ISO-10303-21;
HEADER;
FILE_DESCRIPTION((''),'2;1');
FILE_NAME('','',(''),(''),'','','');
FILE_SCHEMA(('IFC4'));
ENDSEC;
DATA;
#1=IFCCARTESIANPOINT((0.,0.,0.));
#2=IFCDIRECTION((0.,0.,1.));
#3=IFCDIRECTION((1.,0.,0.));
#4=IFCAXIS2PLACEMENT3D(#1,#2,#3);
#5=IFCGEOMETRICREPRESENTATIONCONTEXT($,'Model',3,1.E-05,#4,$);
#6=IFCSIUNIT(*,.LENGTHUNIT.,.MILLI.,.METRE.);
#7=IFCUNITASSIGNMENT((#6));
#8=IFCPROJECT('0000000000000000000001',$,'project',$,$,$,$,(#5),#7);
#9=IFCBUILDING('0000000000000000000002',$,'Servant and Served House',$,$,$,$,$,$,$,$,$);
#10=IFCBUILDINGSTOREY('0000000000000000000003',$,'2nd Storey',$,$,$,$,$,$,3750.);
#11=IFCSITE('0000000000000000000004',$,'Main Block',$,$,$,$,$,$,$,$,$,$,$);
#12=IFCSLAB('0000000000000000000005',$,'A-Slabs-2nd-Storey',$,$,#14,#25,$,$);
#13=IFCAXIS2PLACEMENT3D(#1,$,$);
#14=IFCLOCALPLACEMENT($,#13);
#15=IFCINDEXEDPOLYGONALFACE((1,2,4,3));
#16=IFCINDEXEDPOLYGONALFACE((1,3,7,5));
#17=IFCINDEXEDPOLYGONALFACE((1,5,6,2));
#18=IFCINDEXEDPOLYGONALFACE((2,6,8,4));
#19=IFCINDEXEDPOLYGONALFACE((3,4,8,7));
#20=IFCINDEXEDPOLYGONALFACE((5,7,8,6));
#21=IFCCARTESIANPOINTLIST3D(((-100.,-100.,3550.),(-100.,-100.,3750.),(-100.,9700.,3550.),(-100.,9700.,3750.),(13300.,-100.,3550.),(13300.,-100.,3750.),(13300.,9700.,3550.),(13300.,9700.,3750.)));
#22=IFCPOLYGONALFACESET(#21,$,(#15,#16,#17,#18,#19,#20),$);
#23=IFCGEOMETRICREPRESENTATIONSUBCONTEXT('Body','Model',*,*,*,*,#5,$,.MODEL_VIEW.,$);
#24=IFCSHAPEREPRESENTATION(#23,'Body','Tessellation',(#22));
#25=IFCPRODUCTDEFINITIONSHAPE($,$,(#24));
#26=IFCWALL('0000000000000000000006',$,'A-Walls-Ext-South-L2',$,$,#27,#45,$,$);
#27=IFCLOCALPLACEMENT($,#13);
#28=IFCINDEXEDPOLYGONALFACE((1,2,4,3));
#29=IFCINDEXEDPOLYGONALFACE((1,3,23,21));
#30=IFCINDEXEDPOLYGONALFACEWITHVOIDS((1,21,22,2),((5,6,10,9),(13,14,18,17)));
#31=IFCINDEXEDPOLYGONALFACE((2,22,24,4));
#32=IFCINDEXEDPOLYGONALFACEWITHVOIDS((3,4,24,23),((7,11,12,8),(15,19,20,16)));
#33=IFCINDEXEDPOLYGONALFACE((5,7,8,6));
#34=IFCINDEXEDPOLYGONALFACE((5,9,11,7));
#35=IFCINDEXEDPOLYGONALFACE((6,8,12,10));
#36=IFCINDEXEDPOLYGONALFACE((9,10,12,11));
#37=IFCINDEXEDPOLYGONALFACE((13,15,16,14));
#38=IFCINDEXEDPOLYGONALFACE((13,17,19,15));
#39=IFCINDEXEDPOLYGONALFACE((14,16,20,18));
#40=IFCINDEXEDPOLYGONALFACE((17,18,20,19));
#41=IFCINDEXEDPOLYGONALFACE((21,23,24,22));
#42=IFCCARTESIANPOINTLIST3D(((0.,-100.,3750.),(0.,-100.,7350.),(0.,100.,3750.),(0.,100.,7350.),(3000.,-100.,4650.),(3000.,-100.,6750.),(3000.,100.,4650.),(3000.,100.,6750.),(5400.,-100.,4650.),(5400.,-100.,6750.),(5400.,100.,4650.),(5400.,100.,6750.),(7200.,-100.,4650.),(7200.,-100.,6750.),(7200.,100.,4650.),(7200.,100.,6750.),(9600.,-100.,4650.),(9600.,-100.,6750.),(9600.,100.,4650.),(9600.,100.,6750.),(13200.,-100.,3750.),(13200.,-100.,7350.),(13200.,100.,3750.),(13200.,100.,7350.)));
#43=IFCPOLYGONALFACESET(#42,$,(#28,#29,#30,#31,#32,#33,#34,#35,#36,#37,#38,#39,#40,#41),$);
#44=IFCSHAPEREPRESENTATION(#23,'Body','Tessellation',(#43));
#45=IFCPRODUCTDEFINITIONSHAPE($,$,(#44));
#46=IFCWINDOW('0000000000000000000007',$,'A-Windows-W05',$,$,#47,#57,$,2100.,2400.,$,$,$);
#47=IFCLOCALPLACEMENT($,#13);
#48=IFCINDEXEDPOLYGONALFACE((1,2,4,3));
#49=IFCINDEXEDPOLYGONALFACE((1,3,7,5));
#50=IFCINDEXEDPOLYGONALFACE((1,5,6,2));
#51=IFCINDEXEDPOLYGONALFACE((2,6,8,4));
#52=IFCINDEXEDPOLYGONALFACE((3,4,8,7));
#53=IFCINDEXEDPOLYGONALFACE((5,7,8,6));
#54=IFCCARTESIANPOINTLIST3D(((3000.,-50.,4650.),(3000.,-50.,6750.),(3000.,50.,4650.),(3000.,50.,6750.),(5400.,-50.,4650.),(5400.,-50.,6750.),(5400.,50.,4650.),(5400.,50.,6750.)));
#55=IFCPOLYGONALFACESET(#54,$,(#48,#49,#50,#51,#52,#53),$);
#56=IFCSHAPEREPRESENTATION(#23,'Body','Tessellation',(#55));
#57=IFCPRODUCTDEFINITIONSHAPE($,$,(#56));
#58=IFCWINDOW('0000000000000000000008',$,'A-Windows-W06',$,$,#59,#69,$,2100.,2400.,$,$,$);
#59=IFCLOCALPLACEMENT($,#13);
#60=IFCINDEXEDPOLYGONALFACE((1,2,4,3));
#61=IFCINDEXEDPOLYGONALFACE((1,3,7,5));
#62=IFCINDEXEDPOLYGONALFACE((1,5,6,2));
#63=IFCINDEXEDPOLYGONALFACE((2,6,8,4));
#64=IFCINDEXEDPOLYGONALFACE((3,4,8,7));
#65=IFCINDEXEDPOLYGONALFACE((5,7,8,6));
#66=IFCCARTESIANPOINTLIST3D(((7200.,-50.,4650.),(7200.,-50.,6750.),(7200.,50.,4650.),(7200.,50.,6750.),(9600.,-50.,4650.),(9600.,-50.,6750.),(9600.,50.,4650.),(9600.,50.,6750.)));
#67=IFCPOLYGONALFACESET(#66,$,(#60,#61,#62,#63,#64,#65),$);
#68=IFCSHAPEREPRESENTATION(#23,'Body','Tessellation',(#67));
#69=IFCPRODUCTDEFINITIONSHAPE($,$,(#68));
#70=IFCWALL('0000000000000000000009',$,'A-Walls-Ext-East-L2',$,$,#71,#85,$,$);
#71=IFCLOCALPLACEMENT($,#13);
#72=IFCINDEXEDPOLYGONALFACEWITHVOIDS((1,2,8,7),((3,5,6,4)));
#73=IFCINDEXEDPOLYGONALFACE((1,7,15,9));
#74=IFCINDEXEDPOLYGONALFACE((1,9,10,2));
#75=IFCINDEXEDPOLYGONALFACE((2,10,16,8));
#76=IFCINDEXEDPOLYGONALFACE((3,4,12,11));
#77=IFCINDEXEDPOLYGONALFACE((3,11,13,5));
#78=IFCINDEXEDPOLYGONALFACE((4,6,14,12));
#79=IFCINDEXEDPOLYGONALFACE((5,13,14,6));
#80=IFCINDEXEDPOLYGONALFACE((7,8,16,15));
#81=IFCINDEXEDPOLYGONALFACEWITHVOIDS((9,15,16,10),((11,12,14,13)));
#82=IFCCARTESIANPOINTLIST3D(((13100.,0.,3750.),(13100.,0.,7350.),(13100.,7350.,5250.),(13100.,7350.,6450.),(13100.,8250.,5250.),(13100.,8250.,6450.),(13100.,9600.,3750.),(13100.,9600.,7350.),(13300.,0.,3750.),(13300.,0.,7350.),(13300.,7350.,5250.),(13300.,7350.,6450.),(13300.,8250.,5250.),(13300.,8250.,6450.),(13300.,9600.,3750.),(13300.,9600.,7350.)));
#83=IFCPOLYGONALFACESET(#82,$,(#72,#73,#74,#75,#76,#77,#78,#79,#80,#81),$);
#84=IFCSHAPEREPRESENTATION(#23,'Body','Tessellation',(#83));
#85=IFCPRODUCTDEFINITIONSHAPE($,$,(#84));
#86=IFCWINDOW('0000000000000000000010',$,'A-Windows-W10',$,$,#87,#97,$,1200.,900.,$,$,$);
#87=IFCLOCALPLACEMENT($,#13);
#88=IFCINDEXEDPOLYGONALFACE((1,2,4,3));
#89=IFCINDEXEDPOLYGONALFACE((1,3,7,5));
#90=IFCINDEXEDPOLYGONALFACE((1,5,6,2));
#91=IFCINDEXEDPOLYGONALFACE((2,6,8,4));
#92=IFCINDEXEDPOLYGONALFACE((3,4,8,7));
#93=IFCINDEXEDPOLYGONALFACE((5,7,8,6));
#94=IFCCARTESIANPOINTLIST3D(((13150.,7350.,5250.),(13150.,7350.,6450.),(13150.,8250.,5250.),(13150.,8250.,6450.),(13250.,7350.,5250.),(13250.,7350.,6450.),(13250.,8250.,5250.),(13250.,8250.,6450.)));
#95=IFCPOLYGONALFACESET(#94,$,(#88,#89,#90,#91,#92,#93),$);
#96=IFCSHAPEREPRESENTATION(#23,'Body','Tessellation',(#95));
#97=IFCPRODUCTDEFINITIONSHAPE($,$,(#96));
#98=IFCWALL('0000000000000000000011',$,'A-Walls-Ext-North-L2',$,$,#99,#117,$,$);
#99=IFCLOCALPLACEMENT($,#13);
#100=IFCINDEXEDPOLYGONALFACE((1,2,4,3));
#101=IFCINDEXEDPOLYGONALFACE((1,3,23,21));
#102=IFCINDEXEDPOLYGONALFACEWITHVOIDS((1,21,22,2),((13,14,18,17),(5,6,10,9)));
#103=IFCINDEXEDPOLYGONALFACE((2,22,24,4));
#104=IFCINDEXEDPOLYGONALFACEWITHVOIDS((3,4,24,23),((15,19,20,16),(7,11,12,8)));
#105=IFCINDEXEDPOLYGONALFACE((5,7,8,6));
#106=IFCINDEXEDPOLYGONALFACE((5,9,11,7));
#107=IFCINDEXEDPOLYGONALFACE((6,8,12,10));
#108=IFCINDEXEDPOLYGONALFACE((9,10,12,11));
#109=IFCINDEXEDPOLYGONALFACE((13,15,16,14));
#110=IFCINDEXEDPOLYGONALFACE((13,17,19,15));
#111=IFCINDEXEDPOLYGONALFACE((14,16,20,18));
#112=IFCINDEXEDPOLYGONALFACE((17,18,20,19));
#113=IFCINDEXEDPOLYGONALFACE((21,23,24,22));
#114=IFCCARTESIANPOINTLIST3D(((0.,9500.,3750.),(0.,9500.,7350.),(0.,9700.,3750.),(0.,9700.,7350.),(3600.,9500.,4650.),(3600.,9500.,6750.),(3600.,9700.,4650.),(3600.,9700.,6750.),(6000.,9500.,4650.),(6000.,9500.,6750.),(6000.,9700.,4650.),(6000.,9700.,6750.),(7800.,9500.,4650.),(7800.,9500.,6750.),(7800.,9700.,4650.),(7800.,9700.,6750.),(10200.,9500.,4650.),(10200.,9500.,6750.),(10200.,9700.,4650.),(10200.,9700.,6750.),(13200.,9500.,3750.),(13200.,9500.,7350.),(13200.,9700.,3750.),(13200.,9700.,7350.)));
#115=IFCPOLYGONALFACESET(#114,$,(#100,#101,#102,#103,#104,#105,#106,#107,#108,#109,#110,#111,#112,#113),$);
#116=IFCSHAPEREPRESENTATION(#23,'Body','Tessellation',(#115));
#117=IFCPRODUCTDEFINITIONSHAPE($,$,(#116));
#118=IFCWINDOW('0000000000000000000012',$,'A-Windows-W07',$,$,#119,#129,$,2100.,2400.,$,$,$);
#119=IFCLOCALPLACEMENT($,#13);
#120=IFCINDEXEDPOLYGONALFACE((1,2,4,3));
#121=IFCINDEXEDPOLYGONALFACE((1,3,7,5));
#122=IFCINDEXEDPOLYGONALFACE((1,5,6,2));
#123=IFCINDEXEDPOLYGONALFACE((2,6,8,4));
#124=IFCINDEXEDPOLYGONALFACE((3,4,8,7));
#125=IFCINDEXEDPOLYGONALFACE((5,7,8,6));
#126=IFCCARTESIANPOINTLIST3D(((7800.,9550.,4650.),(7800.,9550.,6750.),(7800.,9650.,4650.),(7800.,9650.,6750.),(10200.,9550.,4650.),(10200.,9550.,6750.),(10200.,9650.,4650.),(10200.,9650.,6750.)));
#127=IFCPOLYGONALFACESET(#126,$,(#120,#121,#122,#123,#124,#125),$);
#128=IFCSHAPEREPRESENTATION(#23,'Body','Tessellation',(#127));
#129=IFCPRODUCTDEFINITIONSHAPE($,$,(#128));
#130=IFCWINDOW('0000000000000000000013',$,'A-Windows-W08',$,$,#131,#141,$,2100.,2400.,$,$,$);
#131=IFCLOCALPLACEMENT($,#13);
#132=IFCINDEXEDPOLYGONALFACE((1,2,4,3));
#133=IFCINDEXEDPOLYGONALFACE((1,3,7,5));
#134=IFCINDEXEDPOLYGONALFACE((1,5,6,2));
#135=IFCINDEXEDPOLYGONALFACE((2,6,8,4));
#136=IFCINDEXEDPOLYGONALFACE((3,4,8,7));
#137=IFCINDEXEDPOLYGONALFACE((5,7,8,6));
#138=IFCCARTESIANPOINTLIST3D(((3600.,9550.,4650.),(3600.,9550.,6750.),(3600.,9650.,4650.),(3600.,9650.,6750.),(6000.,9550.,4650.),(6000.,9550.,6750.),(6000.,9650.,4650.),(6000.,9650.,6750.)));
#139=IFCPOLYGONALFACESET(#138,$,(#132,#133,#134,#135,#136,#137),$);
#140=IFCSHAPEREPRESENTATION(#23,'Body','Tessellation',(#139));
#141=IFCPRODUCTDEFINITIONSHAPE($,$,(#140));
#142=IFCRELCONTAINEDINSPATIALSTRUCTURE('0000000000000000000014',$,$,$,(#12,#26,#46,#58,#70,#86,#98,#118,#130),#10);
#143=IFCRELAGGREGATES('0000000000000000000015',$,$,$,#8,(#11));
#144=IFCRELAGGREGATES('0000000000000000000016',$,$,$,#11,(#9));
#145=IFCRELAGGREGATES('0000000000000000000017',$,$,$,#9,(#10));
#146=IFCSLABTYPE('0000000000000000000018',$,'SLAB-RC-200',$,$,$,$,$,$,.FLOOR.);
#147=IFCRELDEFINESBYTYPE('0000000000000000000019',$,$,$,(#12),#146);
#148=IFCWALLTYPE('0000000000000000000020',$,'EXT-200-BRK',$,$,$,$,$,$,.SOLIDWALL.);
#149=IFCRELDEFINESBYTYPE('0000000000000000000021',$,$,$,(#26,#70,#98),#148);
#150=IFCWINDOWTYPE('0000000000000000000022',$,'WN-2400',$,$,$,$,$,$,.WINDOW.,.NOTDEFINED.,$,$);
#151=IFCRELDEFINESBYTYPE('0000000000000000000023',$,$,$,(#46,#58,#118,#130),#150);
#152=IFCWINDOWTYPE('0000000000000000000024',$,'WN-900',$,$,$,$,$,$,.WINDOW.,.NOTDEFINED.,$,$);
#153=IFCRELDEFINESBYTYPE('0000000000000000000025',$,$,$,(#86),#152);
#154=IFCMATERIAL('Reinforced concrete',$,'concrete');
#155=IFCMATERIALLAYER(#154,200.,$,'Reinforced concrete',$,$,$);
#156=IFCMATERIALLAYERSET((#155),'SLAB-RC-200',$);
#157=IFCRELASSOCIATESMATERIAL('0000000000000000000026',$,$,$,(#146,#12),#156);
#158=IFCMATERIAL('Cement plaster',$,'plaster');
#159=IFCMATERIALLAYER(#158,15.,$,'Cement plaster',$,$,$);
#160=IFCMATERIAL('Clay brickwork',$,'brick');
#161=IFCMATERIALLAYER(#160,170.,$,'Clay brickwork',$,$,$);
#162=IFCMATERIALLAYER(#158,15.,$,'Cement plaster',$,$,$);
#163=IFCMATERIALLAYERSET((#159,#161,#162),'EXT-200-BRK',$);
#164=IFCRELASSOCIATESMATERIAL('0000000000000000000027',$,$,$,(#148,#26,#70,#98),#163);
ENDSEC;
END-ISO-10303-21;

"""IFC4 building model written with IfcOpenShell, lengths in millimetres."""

from ifc_helpers import new_model, si_unit, frame, origin_with_axes, place, context, subcontext, project, spatial, indexed_curve, outline, extrude, material, layer, layer_set, layer_usage, type_object, element, fill, save


model = new_model("IFC4")

# Units and contexts
model_context = context("Model", 3, precision=1e-05, world=origin_with_axes())
body_context = subcontext(model_context, "Body", "Model", "MODEL_VIEW")
ifc_project = project(units=[si_unit("LENGTHUNIT", "METRE", prefix="MILLI")], contexts=[model_context])

# Site, building, storey
site = spatial("IfcSite", under=ifc_project, Name="Main Block")
building = spatial("IfcBuilding", under=site, Name="Servant and Served House")
storey = spatial("IfcBuildingStorey", under=building, Name="2nd Storey", Elevation=3750.0)

# Slab
ifc_material_1 = material(Name="Reinforced concrete", Category="concrete")
ifc_layer_1 = layer(ifc_material_1, 200.0, Name="Reinforced concrete")
ifc_layer_set_1 = layer_set([ifc_layer_1], Name="SLAB-RC-200")
ifc_layer_usage_1 = layer_usage(ifc_layer_set_1, "AXIS3", "POSITIVE", 0.0)
slab_type = type_object("IfcSlabType", Name="SLAB-RC-200", PredefinedType="FLOOR", material=ifc_layer_set_1)
slab_placement = place(None, frame((0.0, 0.0, 3550.0), z_axis=(0.0, 0.0, 1.0), x_axis=(1.0, 0.0, 0.0)))
element("IfcSlab", 1, at=slab_placement, inside=storey, type_object=slab_type, material=ifc_layer_usage_1, Name="A-Slabs-2nd-Storey", context=body_context, shape_type="SweptSolid", body=[
    extrude(outline(indexed_curve([(-100.0, -100.0), (13300.0, -100.0), (13300.0, 9700.0), (-100.0, 9700.0)])), None, (0.0, 0.0, 1.0), 200.0),
])

# Wall, openings, windows
ifc_material_2 = material(Name="Cement plaster", Category="plaster")
ifc_layer_2 = layer(ifc_material_2, 15.0, Name="Cement plaster")
ifc_material_3 = material(Name="Clay brickwork", Category="brick")
ifc_layer_3 = layer(ifc_material_3, 170.0, Name="Clay brickwork")
ifc_layer_4 = layer(ifc_material_2, 15.0, Name="Cement plaster")
ifc_layer_set_2 = layer_set([ifc_layer_2, ifc_layer_3, ifc_layer_4], Name="EXT-200-BRK")
ifc_layer_usage_2 = layer_usage(ifc_layer_set_2, "AXIS2", "POSITIVE", 0.0)
wall_type_1 = type_object("IfcWallType", Name="EXT-200-BRK", PredefinedType="SOLIDWALL", material=ifc_layer_set_2)
wall_1_placement = place(None, frame((0.0, -100.0, 3750.0), z_axis=(0.0, 0.0, 1.0), x_axis=(1.0, 0.0, 0.0)))
wall_1 = element("IfcWall", 2, at=wall_1_placement, inside=storey, type_object=wall_type_1, material=ifc_layer_usage_2, Name="A-Walls-Ext-South-L2", context=body_context, shape_type="SweptSolid", body=[
    extrude(outline(indexed_curve([(0.0, 0.0), (0.0, 200.0), (13200.0, 200.0), (13200.0, 0.0), (0.0, 0.0)], self_intersect=False)), origin_with_axes(), (0.0, 0.0, 1.0), 3600.0),
])
opening_1_placement = place(wall_1_placement, frame((4200.0, 100.0, 900.0), z_axis=(0.0, 0.0, 1.0), x_axis=(1.0, 0.0, 0.0)))
opening_1 = element("IfcOpeningElement", 3, at=opening_1_placement, cuts=wall_1, PredefinedType="OPENING", context=body_context, shape_type="SweptSolid", body=[
    extrude(outline(indexed_curve([(-1200.0, -150.0), (1200.0, -150.0), (1200.0, 150.0), (-1200.0, 150.0)])), None, (0.0, 0.0, 1.0), 2100.0),
])
opening_2_placement = place(wall_1_placement, frame((8400.0, 100.0, 900.0), z_axis=(0.0, 0.0, 1.0), x_axis=(1.0, 0.0, 0.0)))
opening_2 = element("IfcOpeningElement", 4, at=opening_2_placement, cuts=wall_1, PredefinedType="OPENING", context=body_context, shape_type="SweptSolid", body=[
    extrude(outline(indexed_curve([(-1200.0, -150.0), (1200.0, -150.0), (1200.0, 150.0), (-1200.0, 150.0)])), None, (0.0, 0.0, 1.0), 2100.0),
])
window_type_1 = type_object("IfcWindowType", Name="WN-2400", PartitioningType="NOTDEFINED", PredefinedType="WINDOW")
window_1_placement = place(None, frame((4200.0, 0.0, 4650.0), z_axis=(0.0, 0.0, 1.0), x_axis=(1.0, 0.0, 0.0)))
window_1 = element("IfcWindow", 5, at=window_1_placement, inside=storey, type_object=window_type_1, Name="A-Windows-W05", OverallHeight=2100.0, OverallWidth=2400.0, context=body_context, shape_type="SweptSolid", body=[
    extrude(outline(indexed_curve([(-1200.0, -50.0), (1200.0, -50.0), (1200.0, 50.0), (-1200.0, 50.0)])), None, (0.0, 0.0, 1.0), 2100.0),
])
fill(opening_1, window_1)
window_2_placement = place(None, frame((8400.0, 0.0, 4650.0), z_axis=(0.0, 0.0, 1.0), x_axis=(1.0, 0.0, 0.0)))
window_2 = element("IfcWindow", 6, at=window_2_placement, inside=storey, type_object=window_type_1, Name="A-Windows-W06", OverallHeight=2100.0, OverallWidth=2400.0, context=body_context, shape_type="SweptSolid", body=[
    extrude(outline(indexed_curve([(-1200.0, -50.0), (1200.0, -50.0), (1200.0, 50.0), (-1200.0, 50.0)])), None, (0.0, 0.0, 1.0), 2100.0),
])
fill(opening_2, window_2)

# Wall, opening, window
ifc_layer_usage_3 = layer_usage(ifc_layer_set_2, "AXIS2", "POSITIVE", 0.0)
wall_2_placement = place(None, frame((13300.0, 0.0, 3750.0), z_axis=(0.0, 0.0, 1.0), x_axis=(0.0, 1.0, 0.0)))
wall_2 = element("IfcWall", 7, at=wall_2_placement, inside=storey, type_object=wall_type_1, material=ifc_layer_usage_3, Name="A-Walls-Ext-East-L2", context=body_context, shape_type="SweptSolid", body=[
    extrude(outline(indexed_curve([(0.0, 0.0), (0.0, 200.0), (9600.0, 200.0), (9600.0, 0.0), (0.0, 0.0)], self_intersect=False)), origin_with_axes(), (0.0, 0.0, 1.0), 3600.0),
])
opening_3_placement = place(wall_2_placement, frame((7800.0, 100.0, 1500.0), z_axis=(0.0, 0.0, 1.0), x_axis=(1.0, 0.0, 0.0)))
opening_3 = element("IfcOpeningElement", 8, at=opening_3_placement, cuts=wall_2, PredefinedType="OPENING", context=body_context, shape_type="SweptSolid", body=[
    extrude(outline(indexed_curve([(-450.0, -150.0), (450.0, -150.0), (450.0, 150.0), (-450.0, 150.0)])), None, (0.0, 0.0, 1.0), 1200.0),
])
window_type_2 = type_object("IfcWindowType", Name="WN-900", PartitioningType="NOTDEFINED", PredefinedType="WINDOW")
window_3_placement = place(None, frame((13200.0, 7800.0, 5250.0), z_axis=(0.0, 0.0, 1.0), x_axis=(0.0, 1.0, 0.0)))
window_3 = element("IfcWindow", 9, at=window_3_placement, inside=storey, type_object=window_type_2, Name="A-Windows-W10", OverallHeight=1200.0, OverallWidth=900.0, context=body_context, shape_type="SweptSolid", body=[
    extrude(outline(indexed_curve([(-450.0, -50.0), (450.0, -50.0), (450.0, 50.0), (-450.0, 50.0)])), None, (0.0, 0.0, 1.0), 1200.0),
])
fill(opening_3, window_3)

# Wall, openings, windows
ifc_layer_usage_4 = layer_usage(ifc_layer_set_2, "AXIS2", "POSITIVE", 0.0)
wall_3_placement = place(None, frame((13200.0, 9700.0, 3750.0), z_axis=(0.0, 0.0, 1.0), x_axis=(-1.0, 0.0, 0.0)))
wall_3 = element("IfcWall", 10, at=wall_3_placement, inside=storey, type_object=wall_type_1, material=ifc_layer_usage_4, Name="A-Walls-Ext-North-L2", context=body_context, shape_type="SweptSolid", body=[
    extrude(outline(indexed_curve([(0.0, 0.0), (0.0, 200.0), (13200.0, 200.0), (13200.0, 0.0), (0.0, 0.0)], self_intersect=False)), origin_with_axes(), (0.0, 0.0, 1.0), 3600.0),
])
opening_4_placement = place(wall_3_placement, frame((4200.0, 100.0, 900.0), z_axis=(0.0, 0.0, 1.0), x_axis=(1.0, 0.0, 0.0)))
opening_4 = element("IfcOpeningElement", 11, at=opening_4_placement, cuts=wall_3, PredefinedType="OPENING", context=body_context, shape_type="SweptSolid", body=[
    extrude(outline(indexed_curve([(-1200.0, -150.0), (1200.0, -150.0), (1200.0, 150.0), (-1200.0, 150.0)])), None, (0.0, 0.0, 1.0), 2100.0),
])
opening_5_placement = place(wall_3_placement, frame((8400.0, 100.0, 900.0), z_axis=(0.0, 0.0, 1.0), x_axis=(1.0, 0.0, 0.0)))
opening_5 = element("IfcOpeningElement", 12, at=opening_5_placement, cuts=wall_3, PredefinedType="OPENING", context=body_context, shape_type="SweptSolid", body=[
    extrude(outline(indexed_curve([(-1200.0, -150.0), (1200.0, -150.0), (1200.0, 150.0), (-1200.0, 150.0)])), None, (0.0, 0.0, 1.0), 2100.0),
])
window_4_placement = place(None, frame((9000.0, 9600.0, 4650.0), z_axis=(0.0, 0.0, 1.0), x_axis=(-1.0, 0.0, 0.0)))
window_4 = element("IfcWindow", 13, at=window_4_placement, inside=storey, type_object=window_type_1, Name="A-Windows-W07", OverallHeight=2100.0, OverallWidth=2400.0, context=body_context, shape_type="SweptSolid", body=[
    extrude(outline(indexed_curve([(-1200.0, -50.0), (1200.0, -50.0), (1200.0, 50.0), (-1200.0, 50.0)])), None, (0.0, 0.0, 1.0), 2100.0),
])
fill(opening_4, window_4)
window_5_placement = place(None, frame((4800.0, 9600.0, 4650.0), z_axis=(0.0, 0.0, 1.0), x_axis=(-1.0, 0.0, 0.0)))
window_5 = element("IfcWindow", 14, at=window_5_placement, inside=storey, type_object=window_type_1, Name="A-Windows-W08", OverallHeight=2100.0, OverallWidth=2400.0, context=body_context, shape_type="SweptSolid", body=[
    extrude(outline(indexed_curve([(-1200.0, -50.0), (1200.0, -50.0), (1200.0, 50.0), (-1200.0, 50.0)])), None, (0.0, 0.0, 1.0), 2100.0),
])
fill(opening_5, window_5)

save(model, "model.ifc")
